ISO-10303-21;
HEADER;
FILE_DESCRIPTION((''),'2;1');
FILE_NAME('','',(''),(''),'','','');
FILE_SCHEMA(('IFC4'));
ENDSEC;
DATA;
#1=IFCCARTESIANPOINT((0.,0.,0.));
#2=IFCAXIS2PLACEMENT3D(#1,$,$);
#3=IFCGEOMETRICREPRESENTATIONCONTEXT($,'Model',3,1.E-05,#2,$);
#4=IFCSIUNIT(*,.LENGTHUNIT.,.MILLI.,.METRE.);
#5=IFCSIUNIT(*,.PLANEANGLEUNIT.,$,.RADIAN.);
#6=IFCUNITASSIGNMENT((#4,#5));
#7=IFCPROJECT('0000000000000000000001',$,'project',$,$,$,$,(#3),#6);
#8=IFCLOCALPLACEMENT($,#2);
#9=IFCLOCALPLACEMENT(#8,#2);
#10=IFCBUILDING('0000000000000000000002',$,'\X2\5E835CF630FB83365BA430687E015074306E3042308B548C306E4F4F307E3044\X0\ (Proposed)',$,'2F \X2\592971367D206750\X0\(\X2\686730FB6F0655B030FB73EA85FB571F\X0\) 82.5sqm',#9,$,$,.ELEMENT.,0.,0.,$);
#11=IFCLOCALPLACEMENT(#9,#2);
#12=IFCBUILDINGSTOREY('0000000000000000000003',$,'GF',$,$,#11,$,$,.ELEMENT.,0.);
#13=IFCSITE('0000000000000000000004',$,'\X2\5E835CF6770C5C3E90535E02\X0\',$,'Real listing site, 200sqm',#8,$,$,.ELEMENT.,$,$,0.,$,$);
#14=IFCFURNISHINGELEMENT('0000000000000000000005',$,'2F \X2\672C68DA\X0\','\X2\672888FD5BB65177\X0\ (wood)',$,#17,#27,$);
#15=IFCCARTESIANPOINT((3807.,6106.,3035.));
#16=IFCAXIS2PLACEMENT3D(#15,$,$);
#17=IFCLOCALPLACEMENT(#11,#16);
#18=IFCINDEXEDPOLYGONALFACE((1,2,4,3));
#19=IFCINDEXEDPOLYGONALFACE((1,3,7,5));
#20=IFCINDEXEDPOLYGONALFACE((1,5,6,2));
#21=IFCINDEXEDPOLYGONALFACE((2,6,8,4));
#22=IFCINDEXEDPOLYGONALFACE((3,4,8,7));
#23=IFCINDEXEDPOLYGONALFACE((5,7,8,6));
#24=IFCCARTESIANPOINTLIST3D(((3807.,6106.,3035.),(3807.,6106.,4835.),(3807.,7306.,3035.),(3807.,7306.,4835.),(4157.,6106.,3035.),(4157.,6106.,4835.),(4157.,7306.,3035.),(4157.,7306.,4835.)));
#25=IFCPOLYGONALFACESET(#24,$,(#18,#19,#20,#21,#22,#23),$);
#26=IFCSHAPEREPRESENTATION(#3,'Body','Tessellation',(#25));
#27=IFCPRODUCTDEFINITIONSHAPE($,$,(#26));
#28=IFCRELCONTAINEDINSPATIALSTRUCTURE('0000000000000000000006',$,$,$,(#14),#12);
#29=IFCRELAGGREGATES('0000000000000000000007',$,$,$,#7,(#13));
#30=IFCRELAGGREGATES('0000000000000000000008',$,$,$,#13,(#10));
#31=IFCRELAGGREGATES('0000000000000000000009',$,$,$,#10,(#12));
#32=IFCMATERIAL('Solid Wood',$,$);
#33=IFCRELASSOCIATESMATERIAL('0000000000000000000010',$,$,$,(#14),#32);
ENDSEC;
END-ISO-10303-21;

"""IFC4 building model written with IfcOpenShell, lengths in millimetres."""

from ifc_helpers import new_model, si_unit, frame, frame_2d, origin, place, context, project, spatial, rectangle, extrude, material, element, save


model = new_model("IFC4")

# Units and contexts
model_context = context("Model", 3, precision=1e-05, world=origin())
ifc_project = project(units=[si_unit("LENGTHUNIT", "METRE", prefix="MILLI"), si_unit("PLANEANGLEUNIT", "RADIAN")], contexts=[model_context])

# Site, building, storey
site_placement = place(None, origin())
site = spatial("IfcSite", under=ifc_project, at=site_placement, Name="広島県尾道市", ObjectType="Real listing site, 200sqm", CompositionType="ELEMENT", RefElevation=0.0)
building_placement = place(site_placement, origin())
building = spatial("IfcBuilding", under=site, at=building_placement, Name="広島・茶室と縁側のある和の住まい (Proposed)", ObjectType="2F 天然素材(桧・漆喰・珪藻土) 82.5sqm", CompositionType="ELEMENT", ElevationOfRefHeight=0.0, ElevationOfTerrain=0.0)
storey_placement = place(building_placement, origin())
storey = spatial("IfcBuildingStorey", under=building, at=storey_placement, Name="GF", CompositionType="ELEMENT", Elevation=0.0)

# Shared definitions
ifc_material_1 = material(Name="Solid Wood")

# Furnishing element
furnishing_1_placement = place(storey_placement, frame((3807.0, 6106.0, 3035.0)))
element("IfcFurnishingElement", 1, at=furnishing_1_placement, inside=storey, material=ifc_material_1, Name="2F 本棚", Description="木製家具 (wood)", context=model_context, shape_type="SweptSolid", body=[
    extrude(rectangle(XDim=350.0, YDim=1200.0, at=frame_2d((175.0, 600.0))), frame((3807.0, 6106.0, 3035.0)), (0.0, 0.0, 1.0), 1800.0),
])

save(model, "model.ifc")
